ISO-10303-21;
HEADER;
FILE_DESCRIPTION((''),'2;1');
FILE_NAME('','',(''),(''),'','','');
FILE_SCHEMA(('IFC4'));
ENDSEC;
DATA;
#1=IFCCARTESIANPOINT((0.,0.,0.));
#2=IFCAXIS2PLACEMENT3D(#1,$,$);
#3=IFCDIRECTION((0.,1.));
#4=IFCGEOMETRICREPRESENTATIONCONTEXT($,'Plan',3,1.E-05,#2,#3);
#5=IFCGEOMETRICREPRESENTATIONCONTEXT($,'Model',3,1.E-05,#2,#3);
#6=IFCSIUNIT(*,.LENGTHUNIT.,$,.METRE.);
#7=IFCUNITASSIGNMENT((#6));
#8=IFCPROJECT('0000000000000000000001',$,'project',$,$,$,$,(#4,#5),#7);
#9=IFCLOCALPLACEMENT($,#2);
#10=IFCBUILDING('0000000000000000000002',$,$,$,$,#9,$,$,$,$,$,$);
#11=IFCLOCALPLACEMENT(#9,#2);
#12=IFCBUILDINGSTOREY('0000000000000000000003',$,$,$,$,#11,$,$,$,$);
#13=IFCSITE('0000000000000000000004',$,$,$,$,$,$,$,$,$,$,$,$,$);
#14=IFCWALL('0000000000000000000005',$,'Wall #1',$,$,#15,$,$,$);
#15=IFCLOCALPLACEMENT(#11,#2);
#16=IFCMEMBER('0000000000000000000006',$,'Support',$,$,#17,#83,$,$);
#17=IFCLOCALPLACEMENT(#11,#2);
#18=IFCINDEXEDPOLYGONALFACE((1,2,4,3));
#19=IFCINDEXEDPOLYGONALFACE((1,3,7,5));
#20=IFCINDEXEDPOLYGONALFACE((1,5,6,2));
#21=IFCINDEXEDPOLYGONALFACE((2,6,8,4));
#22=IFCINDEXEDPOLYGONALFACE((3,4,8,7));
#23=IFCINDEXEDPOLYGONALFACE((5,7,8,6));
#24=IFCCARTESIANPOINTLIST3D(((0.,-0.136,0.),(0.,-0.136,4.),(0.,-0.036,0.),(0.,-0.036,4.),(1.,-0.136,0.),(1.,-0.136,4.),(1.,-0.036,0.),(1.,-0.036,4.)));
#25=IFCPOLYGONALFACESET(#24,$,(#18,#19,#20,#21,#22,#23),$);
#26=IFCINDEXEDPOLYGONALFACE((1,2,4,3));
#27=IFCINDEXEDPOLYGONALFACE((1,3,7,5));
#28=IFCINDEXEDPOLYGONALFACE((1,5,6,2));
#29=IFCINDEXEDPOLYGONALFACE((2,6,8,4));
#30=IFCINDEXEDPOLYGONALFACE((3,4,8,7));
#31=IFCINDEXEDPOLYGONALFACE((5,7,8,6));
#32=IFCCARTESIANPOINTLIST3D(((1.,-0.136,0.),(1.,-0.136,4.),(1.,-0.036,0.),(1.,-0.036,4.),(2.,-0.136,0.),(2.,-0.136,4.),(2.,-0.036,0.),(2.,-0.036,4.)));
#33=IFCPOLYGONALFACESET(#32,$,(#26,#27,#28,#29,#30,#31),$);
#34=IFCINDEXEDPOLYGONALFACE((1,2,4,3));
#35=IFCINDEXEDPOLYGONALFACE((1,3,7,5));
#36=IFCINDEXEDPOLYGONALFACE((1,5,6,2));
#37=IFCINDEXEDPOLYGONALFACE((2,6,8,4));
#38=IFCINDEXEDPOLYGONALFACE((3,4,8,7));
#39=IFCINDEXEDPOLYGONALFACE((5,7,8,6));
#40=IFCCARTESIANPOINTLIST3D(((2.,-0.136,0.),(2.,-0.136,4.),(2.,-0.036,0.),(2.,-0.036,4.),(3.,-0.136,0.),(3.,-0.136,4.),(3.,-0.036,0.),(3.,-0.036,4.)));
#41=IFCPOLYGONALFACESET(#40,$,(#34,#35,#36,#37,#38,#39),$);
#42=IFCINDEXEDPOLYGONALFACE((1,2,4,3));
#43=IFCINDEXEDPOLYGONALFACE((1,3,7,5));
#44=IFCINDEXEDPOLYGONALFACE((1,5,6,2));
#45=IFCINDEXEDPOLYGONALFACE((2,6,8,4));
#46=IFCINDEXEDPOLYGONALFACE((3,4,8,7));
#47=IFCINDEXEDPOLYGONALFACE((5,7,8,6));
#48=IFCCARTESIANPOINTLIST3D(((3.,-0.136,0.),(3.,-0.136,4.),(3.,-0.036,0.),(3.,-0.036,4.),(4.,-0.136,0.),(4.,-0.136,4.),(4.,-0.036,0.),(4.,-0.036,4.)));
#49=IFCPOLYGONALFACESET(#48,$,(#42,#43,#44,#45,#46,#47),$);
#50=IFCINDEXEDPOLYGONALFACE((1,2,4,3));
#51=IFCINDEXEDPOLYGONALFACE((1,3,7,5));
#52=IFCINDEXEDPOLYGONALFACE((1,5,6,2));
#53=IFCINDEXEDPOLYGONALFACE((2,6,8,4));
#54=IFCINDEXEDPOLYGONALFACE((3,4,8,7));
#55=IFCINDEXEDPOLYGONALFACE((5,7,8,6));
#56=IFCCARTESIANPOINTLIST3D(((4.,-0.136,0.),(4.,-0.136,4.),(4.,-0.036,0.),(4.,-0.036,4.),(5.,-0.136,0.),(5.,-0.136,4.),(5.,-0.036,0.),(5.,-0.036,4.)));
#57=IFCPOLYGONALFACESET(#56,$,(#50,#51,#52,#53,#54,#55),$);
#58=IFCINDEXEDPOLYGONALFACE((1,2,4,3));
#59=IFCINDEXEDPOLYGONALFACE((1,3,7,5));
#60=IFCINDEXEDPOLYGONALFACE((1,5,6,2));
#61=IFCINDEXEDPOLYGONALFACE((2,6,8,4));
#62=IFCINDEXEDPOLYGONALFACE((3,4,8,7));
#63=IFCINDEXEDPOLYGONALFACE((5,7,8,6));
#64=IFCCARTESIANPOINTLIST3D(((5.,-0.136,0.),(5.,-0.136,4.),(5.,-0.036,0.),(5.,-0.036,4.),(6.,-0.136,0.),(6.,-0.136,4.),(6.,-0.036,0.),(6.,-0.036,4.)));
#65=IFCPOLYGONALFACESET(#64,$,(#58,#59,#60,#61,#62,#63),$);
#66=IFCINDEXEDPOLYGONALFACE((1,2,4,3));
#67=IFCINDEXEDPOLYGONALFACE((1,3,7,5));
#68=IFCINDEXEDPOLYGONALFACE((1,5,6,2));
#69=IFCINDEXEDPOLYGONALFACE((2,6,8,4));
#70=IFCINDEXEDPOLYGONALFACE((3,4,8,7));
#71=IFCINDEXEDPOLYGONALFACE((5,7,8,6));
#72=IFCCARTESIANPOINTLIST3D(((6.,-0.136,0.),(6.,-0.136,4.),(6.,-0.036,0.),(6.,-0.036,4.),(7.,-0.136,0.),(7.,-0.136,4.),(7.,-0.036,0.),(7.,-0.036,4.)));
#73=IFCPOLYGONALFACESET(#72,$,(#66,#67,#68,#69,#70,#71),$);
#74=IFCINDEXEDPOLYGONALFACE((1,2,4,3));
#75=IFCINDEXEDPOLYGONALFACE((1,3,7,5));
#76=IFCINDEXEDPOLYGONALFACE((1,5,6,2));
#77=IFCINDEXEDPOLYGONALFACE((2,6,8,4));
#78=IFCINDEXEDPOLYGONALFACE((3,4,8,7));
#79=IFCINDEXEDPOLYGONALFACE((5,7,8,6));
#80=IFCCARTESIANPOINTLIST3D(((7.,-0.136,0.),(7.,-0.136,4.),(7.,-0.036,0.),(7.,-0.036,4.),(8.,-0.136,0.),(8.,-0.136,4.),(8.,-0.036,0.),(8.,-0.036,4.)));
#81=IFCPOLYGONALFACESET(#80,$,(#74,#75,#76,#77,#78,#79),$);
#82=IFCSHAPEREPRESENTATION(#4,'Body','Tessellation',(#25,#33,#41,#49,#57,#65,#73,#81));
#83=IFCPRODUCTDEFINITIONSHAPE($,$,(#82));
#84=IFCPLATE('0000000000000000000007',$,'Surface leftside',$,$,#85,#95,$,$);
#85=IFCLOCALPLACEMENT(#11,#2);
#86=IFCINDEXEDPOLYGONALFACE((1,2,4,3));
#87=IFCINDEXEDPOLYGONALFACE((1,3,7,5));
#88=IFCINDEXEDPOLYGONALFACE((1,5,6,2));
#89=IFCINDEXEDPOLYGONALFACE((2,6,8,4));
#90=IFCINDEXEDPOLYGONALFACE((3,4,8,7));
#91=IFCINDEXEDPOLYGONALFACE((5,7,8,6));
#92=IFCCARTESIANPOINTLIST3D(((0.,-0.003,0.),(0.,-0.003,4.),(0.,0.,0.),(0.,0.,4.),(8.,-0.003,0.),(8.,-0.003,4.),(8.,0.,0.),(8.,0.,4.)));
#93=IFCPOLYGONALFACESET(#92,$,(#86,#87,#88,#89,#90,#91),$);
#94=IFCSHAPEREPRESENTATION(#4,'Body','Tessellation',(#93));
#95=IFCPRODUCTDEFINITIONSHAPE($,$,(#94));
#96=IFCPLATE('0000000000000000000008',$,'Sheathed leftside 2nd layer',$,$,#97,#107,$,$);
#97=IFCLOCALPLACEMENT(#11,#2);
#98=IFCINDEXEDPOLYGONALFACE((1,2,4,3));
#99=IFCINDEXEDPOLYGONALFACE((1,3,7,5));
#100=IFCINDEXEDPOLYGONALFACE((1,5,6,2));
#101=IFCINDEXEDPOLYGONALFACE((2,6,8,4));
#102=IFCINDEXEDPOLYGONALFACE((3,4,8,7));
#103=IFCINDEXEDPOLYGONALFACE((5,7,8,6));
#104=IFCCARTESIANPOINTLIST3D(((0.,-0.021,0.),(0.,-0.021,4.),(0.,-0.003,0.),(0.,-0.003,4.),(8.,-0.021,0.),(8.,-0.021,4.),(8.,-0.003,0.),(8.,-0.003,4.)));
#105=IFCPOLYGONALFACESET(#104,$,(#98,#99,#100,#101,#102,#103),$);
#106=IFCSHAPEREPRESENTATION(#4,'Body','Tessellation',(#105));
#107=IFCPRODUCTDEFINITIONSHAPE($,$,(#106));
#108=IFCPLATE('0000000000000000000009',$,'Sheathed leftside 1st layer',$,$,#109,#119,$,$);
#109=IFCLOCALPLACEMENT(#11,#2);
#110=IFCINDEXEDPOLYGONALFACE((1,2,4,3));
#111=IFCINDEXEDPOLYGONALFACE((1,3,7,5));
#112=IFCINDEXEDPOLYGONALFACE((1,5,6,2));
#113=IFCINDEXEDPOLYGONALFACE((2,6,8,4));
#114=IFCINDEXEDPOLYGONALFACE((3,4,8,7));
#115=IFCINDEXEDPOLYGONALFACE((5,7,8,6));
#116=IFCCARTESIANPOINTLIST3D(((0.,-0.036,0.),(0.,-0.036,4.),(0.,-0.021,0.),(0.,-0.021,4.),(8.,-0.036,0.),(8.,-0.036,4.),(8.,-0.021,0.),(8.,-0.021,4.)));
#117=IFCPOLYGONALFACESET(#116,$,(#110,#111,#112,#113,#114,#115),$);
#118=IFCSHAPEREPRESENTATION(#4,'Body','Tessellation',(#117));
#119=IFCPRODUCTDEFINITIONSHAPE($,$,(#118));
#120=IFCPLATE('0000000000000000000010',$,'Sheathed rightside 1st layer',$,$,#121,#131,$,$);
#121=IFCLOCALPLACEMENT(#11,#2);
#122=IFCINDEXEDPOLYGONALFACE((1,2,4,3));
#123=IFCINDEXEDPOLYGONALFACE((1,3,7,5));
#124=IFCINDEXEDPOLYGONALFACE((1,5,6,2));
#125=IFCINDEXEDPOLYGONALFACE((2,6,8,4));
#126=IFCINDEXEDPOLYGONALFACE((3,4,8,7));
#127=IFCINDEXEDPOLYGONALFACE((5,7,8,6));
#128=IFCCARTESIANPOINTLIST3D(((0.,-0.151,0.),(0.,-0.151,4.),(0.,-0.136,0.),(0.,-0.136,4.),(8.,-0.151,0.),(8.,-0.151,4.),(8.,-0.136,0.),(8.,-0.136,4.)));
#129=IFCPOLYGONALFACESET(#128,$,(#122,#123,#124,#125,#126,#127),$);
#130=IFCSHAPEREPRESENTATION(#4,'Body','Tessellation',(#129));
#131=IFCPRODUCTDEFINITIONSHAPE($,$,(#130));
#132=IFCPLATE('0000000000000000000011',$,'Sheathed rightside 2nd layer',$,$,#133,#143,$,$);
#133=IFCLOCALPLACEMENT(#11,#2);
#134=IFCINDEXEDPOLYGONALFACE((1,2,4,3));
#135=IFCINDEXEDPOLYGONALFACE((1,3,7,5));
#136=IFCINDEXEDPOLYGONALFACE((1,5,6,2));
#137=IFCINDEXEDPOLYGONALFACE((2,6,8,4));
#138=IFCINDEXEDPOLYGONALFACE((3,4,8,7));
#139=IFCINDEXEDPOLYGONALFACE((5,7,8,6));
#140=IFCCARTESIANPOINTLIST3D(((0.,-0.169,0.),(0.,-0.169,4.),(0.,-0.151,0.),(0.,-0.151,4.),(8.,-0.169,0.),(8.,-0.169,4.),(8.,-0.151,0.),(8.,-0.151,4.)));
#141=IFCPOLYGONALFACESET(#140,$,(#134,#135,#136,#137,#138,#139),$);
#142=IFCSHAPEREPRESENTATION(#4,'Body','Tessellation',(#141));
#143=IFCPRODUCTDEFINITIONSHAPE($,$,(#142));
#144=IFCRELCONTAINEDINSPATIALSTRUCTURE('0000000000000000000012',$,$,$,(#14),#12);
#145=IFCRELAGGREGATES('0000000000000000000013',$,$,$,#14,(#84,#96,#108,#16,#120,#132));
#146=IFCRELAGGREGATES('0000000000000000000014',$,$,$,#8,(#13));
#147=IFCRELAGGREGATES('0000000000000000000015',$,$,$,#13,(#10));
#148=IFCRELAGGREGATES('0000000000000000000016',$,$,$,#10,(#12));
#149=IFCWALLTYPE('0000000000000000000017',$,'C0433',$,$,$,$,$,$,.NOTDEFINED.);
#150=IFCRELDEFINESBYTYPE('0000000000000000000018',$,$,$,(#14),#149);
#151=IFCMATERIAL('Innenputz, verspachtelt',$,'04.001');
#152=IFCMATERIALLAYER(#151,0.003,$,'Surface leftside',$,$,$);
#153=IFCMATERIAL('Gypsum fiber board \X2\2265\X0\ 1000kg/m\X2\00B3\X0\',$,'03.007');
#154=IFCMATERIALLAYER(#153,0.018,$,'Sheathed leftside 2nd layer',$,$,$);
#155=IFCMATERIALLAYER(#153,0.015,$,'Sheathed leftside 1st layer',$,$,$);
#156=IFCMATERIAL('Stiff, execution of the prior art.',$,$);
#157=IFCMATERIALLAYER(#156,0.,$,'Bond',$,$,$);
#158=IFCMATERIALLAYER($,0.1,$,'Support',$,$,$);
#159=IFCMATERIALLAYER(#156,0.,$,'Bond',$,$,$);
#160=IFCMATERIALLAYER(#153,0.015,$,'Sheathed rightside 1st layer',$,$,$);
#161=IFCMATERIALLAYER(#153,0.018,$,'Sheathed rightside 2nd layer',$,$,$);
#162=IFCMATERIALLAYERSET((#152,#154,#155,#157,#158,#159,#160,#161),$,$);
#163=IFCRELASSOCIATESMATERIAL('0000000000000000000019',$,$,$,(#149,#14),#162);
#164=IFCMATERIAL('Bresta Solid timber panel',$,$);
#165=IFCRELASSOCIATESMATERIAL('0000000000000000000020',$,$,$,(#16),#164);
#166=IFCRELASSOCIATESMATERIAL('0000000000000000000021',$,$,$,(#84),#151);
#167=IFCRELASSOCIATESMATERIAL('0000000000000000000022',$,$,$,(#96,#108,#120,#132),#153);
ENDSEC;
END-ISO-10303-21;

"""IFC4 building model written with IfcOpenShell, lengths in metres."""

from ifc_helpers import new_model, si_unit, direction, frame, frame_2d, origin, origin_with_axes, place, context, project, spatial, rectangle, extrude, material, layer, layer_set, type_object, element, aggregate, save


model = new_model("IFC4")

# Units and contexts
plan_context = context("Plan", 3, precision=1e-05, world=origin(), true_north=direction((0.0, 1.0)))
model_context = context("Model", 3, precision=1e-05, world=origin(), true_north=direction((0.0, 1.0)))
ifc_project = project(units=[si_unit("LENGTHUNIT", "METRE")], contexts=[plan_context, model_context])

# Site, building, storey
site = spatial("IfcSite", under=ifc_project)
building_placement = place(None, origin())
building = spatial("IfcBuilding", under=site, at=building_placement)
storey_placement = place(building_placement, origin())
storey = spatial("IfcBuildingStorey", under=building, at=storey_placement)

# Wall, member, plates
ifc_material_1 = material(Name="Innenputz, verspachtelt", Category="04.001")
ifc_layer_1 = layer(ifc_material_1, 0.003, Name="Surface leftside")
ifc_material_2 = material(Name="Gypsum fiber board ≥ 1000kg/m³", Category="03.007")
ifc_layer_2 = layer(ifc_material_2, 0.018, Name="Sheathed leftside 2nd layer")
ifc_layer_3 = layer(ifc_material_2, 0.015, Name="Sheathed leftside 1st layer")
ifc_material_3 = material(Name="Stiff, execution of the prior art.")
ifc_layer_4 = layer(ifc_material_3, 0.0, Name="Bond")
ifc_layer_5 = layer(None, 0.1, Name="Support")
ifc_layer_6 = layer(ifc_material_3, 0.0, Name="Bond")
ifc_layer_7 = layer(ifc_material_2, 0.015, Name="Sheathed rightside 1st layer")
ifc_layer_8 = layer(ifc_material_2, 0.018, Name="Sheathed rightside 2nd layer")
ifc_layer_set = layer_set([ifc_layer_1, ifc_layer_2, ifc_layer_3, ifc_layer_4, ifc_layer_5, ifc_layer_6, ifc_layer_7, ifc_layer_8])
wall_type = type_object("IfcWallType", Name="C0433", PredefinedType="NOTDEFINED", material=ifc_layer_set)
wall_placement = place(None, frame((0.0, 0.0, 0.0), z_axis=(0.0, -1.0, 0.0), x_axis=(1.0, 0.0, 0.0)))
wall = element("IfcWall", 1, at=wall_placement, inside=storey, type_object=wall_type, material=ifc_layer_set, Name="Wall #1")
ifc_material_4 = material(Name="Bresta Solid timber panel")
member_placement = place(wall_placement, origin())
member = element("IfcMember", 2, at=member_placement, material=ifc_material_4, Name="Support", context=plan_context, shape_type="SweptSolid", body=[
    extrude(rectangle(XDim=1.0, YDim=0.1, at=frame_2d((0.5, 0.05), x_axis=(1.0, 0.0))), frame((0.0, 4.0, 0.036), z_axis=(0.0, -1.0, 0.0), x_axis=(1.0, 0.0, 0.0)), (0.0, 0.0, 1.0), 4.0),
    extrude(rectangle(XDim=1.0, YDim=0.1, at=frame_2d((0.5, 0.05), x_axis=(1.0, 0.0))), frame((1.0, 4.0, 0.036), z_axis=(0.0, -1.0, 0.0), x_axis=(1.0, 0.0, 0.0)), (0.0, 0.0, 1.0), 4.0),
    extrude(rectangle(XDim=1.0, YDim=0.1, at=frame_2d((0.5, 0.05), x_axis=(1.0, 0.0))), frame((2.0, 4.0, 0.036), z_axis=(0.0, -1.0, 0.0), x_axis=(1.0, 0.0, 0.0)), (0.0, 0.0, 1.0), 4.0),
    extrude(rectangle(XDim=1.0, YDim=0.1, at=frame_2d((0.5, 0.05), x_axis=(1.0, 0.0))), frame((3.0, 4.0, 0.036), z_axis=(0.0, -1.0, 0.0), x_axis=(1.0, 0.0, 0.0)), (0.0, 0.0, 1.0), 4.0),
    extrude(rectangle(XDim=1.0, YDim=0.1, at=frame_2d((0.5, 0.05), x_axis=(1.0, 0.0))), frame((4.0, 4.0, 0.036), z_axis=(0.0, -1.0, 0.0), x_axis=(1.0, 0.0, 0.0)), (0.0, 0.0, 1.0), 4.0),
    extrude(rectangle(XDim=1.0, YDim=0.1, at=frame_2d((0.5, 0.05), x_axis=(1.0, 0.0))), frame((5.0, 4.0, 0.036), z_axis=(0.0, -1.0, 0.0), x_axis=(1.0, 0.0, 0.0)), (0.0, 0.0, 1.0), 4.0),
    extrude(rectangle(XDim=1.0, YDim=0.1, at=frame_2d((0.5, 0.05), x_axis=(1.0, 0.0))), frame((6.0, 4.0, 0.036), z_axis=(0.0, -1.0, 0.0), x_axis=(1.0, 0.0, 0.0)), (0.0, 0.0, 1.0), 4.0),
    extrude(rectangle(XDim=1.0, YDim=0.1, at=frame_2d((0.5, 0.05), x_axis=(1.0, 0.0))), frame((7.0, 4.0, 0.036), z_axis=(0.0, -1.0, 0.0), x_axis=(1.0, 0.0, 0.0)), (0.0, 0.0, 1.0), 4.0),
])
plate_1_placement = place(wall_placement, origin())
plate_1 = element("IfcPlate", 3, at=plate_1_placement, material=ifc_material_1, Name="Surface leftside", context=plan_context, shape_type="SweptSolid", body=[
    extrude(rectangle(XDim=8.0, YDim=4.0, at=frame_2d((4.0, 2.0), x_axis=(1.0, 0.0))), origin_with_axes(), (0.0, 0.0, 1.0), 0.003),
])
plate_2_placement = place(wall_placement, origin())
plate_2 = element("IfcPlate", 4, at=plate_2_placement, material=ifc_material_2, Name="Sheathed leftside 2nd layer", context=plan_context, shape_type="SweptSolid", body=[
    extrude(rectangle(XDim=8.0, YDim=4.0, at=frame_2d((4.0, 2.0), x_axis=(1.0, 0.0))), frame((0.0, 0.0, 0.003), z_axis=(0.0, 0.0, 1.0), x_axis=(1.0, 0.0, 0.0)), (0.0, 0.0, 1.0), 0.018),
])
plate_3_placement = place(wall_placement, origin())
plate_3 = element("IfcPlate", 5, at=plate_3_placement, material=ifc_material_2, Name="Sheathed leftside 1st layer", context=plan_context, shape_type="SweptSolid", body=[
    extrude(rectangle(XDim=8.0, YDim=4.0, at=frame_2d((4.0, 2.0), x_axis=(1.0, 0.0))), frame((0.0, 0.0, 0.021), z_axis=(0.0, 0.0, 1.0), x_axis=(1.0, 0.0, 0.0)), (0.0, 0.0, 1.0), 0.015),
])
plate_4_placement = place(wall_placement, origin())
plate_4 = element("IfcPlate", 6, at=plate_4_placement, material=ifc_material_2, Name="Sheathed rightside 1st layer", context=plan_context, shape_type="SweptSolid", body=[
    extrude(rectangle(XDim=8.0, YDim=4.0, at=frame_2d((4.0, 2.0), x_axis=(1.0, 0.0))), frame((0.0, 0.0, 0.136), z_axis=(0.0, 0.0, 1.0), x_axis=(1.0, 0.0, 0.0)), (0.0, 0.0, 1.0), 0.015),
])
plate_5_placement = place(wall_placement, origin())
plate_5 = element("IfcPlate", 7, at=plate_5_placement, material=ifc_material_2, Name="Sheathed rightside 2nd layer", context=plan_context, shape_type="SweptSolid", body=[
    extrude(rectangle(XDim=8.0, YDim=4.0, at=frame_2d((4.0, 2.0), x_axis=(1.0, 0.0))), frame((0.0, 0.0, 0.151), z_axis=(0.0, 0.0, 1.0), x_axis=(1.0, 0.0, 0.0)), (0.0, 0.0, 1.0), 0.018),
])
aggregate(wall, [plate_1, plate_2, plate_3, member, plate_4, plate_5])

save(model, "model.ifc")
